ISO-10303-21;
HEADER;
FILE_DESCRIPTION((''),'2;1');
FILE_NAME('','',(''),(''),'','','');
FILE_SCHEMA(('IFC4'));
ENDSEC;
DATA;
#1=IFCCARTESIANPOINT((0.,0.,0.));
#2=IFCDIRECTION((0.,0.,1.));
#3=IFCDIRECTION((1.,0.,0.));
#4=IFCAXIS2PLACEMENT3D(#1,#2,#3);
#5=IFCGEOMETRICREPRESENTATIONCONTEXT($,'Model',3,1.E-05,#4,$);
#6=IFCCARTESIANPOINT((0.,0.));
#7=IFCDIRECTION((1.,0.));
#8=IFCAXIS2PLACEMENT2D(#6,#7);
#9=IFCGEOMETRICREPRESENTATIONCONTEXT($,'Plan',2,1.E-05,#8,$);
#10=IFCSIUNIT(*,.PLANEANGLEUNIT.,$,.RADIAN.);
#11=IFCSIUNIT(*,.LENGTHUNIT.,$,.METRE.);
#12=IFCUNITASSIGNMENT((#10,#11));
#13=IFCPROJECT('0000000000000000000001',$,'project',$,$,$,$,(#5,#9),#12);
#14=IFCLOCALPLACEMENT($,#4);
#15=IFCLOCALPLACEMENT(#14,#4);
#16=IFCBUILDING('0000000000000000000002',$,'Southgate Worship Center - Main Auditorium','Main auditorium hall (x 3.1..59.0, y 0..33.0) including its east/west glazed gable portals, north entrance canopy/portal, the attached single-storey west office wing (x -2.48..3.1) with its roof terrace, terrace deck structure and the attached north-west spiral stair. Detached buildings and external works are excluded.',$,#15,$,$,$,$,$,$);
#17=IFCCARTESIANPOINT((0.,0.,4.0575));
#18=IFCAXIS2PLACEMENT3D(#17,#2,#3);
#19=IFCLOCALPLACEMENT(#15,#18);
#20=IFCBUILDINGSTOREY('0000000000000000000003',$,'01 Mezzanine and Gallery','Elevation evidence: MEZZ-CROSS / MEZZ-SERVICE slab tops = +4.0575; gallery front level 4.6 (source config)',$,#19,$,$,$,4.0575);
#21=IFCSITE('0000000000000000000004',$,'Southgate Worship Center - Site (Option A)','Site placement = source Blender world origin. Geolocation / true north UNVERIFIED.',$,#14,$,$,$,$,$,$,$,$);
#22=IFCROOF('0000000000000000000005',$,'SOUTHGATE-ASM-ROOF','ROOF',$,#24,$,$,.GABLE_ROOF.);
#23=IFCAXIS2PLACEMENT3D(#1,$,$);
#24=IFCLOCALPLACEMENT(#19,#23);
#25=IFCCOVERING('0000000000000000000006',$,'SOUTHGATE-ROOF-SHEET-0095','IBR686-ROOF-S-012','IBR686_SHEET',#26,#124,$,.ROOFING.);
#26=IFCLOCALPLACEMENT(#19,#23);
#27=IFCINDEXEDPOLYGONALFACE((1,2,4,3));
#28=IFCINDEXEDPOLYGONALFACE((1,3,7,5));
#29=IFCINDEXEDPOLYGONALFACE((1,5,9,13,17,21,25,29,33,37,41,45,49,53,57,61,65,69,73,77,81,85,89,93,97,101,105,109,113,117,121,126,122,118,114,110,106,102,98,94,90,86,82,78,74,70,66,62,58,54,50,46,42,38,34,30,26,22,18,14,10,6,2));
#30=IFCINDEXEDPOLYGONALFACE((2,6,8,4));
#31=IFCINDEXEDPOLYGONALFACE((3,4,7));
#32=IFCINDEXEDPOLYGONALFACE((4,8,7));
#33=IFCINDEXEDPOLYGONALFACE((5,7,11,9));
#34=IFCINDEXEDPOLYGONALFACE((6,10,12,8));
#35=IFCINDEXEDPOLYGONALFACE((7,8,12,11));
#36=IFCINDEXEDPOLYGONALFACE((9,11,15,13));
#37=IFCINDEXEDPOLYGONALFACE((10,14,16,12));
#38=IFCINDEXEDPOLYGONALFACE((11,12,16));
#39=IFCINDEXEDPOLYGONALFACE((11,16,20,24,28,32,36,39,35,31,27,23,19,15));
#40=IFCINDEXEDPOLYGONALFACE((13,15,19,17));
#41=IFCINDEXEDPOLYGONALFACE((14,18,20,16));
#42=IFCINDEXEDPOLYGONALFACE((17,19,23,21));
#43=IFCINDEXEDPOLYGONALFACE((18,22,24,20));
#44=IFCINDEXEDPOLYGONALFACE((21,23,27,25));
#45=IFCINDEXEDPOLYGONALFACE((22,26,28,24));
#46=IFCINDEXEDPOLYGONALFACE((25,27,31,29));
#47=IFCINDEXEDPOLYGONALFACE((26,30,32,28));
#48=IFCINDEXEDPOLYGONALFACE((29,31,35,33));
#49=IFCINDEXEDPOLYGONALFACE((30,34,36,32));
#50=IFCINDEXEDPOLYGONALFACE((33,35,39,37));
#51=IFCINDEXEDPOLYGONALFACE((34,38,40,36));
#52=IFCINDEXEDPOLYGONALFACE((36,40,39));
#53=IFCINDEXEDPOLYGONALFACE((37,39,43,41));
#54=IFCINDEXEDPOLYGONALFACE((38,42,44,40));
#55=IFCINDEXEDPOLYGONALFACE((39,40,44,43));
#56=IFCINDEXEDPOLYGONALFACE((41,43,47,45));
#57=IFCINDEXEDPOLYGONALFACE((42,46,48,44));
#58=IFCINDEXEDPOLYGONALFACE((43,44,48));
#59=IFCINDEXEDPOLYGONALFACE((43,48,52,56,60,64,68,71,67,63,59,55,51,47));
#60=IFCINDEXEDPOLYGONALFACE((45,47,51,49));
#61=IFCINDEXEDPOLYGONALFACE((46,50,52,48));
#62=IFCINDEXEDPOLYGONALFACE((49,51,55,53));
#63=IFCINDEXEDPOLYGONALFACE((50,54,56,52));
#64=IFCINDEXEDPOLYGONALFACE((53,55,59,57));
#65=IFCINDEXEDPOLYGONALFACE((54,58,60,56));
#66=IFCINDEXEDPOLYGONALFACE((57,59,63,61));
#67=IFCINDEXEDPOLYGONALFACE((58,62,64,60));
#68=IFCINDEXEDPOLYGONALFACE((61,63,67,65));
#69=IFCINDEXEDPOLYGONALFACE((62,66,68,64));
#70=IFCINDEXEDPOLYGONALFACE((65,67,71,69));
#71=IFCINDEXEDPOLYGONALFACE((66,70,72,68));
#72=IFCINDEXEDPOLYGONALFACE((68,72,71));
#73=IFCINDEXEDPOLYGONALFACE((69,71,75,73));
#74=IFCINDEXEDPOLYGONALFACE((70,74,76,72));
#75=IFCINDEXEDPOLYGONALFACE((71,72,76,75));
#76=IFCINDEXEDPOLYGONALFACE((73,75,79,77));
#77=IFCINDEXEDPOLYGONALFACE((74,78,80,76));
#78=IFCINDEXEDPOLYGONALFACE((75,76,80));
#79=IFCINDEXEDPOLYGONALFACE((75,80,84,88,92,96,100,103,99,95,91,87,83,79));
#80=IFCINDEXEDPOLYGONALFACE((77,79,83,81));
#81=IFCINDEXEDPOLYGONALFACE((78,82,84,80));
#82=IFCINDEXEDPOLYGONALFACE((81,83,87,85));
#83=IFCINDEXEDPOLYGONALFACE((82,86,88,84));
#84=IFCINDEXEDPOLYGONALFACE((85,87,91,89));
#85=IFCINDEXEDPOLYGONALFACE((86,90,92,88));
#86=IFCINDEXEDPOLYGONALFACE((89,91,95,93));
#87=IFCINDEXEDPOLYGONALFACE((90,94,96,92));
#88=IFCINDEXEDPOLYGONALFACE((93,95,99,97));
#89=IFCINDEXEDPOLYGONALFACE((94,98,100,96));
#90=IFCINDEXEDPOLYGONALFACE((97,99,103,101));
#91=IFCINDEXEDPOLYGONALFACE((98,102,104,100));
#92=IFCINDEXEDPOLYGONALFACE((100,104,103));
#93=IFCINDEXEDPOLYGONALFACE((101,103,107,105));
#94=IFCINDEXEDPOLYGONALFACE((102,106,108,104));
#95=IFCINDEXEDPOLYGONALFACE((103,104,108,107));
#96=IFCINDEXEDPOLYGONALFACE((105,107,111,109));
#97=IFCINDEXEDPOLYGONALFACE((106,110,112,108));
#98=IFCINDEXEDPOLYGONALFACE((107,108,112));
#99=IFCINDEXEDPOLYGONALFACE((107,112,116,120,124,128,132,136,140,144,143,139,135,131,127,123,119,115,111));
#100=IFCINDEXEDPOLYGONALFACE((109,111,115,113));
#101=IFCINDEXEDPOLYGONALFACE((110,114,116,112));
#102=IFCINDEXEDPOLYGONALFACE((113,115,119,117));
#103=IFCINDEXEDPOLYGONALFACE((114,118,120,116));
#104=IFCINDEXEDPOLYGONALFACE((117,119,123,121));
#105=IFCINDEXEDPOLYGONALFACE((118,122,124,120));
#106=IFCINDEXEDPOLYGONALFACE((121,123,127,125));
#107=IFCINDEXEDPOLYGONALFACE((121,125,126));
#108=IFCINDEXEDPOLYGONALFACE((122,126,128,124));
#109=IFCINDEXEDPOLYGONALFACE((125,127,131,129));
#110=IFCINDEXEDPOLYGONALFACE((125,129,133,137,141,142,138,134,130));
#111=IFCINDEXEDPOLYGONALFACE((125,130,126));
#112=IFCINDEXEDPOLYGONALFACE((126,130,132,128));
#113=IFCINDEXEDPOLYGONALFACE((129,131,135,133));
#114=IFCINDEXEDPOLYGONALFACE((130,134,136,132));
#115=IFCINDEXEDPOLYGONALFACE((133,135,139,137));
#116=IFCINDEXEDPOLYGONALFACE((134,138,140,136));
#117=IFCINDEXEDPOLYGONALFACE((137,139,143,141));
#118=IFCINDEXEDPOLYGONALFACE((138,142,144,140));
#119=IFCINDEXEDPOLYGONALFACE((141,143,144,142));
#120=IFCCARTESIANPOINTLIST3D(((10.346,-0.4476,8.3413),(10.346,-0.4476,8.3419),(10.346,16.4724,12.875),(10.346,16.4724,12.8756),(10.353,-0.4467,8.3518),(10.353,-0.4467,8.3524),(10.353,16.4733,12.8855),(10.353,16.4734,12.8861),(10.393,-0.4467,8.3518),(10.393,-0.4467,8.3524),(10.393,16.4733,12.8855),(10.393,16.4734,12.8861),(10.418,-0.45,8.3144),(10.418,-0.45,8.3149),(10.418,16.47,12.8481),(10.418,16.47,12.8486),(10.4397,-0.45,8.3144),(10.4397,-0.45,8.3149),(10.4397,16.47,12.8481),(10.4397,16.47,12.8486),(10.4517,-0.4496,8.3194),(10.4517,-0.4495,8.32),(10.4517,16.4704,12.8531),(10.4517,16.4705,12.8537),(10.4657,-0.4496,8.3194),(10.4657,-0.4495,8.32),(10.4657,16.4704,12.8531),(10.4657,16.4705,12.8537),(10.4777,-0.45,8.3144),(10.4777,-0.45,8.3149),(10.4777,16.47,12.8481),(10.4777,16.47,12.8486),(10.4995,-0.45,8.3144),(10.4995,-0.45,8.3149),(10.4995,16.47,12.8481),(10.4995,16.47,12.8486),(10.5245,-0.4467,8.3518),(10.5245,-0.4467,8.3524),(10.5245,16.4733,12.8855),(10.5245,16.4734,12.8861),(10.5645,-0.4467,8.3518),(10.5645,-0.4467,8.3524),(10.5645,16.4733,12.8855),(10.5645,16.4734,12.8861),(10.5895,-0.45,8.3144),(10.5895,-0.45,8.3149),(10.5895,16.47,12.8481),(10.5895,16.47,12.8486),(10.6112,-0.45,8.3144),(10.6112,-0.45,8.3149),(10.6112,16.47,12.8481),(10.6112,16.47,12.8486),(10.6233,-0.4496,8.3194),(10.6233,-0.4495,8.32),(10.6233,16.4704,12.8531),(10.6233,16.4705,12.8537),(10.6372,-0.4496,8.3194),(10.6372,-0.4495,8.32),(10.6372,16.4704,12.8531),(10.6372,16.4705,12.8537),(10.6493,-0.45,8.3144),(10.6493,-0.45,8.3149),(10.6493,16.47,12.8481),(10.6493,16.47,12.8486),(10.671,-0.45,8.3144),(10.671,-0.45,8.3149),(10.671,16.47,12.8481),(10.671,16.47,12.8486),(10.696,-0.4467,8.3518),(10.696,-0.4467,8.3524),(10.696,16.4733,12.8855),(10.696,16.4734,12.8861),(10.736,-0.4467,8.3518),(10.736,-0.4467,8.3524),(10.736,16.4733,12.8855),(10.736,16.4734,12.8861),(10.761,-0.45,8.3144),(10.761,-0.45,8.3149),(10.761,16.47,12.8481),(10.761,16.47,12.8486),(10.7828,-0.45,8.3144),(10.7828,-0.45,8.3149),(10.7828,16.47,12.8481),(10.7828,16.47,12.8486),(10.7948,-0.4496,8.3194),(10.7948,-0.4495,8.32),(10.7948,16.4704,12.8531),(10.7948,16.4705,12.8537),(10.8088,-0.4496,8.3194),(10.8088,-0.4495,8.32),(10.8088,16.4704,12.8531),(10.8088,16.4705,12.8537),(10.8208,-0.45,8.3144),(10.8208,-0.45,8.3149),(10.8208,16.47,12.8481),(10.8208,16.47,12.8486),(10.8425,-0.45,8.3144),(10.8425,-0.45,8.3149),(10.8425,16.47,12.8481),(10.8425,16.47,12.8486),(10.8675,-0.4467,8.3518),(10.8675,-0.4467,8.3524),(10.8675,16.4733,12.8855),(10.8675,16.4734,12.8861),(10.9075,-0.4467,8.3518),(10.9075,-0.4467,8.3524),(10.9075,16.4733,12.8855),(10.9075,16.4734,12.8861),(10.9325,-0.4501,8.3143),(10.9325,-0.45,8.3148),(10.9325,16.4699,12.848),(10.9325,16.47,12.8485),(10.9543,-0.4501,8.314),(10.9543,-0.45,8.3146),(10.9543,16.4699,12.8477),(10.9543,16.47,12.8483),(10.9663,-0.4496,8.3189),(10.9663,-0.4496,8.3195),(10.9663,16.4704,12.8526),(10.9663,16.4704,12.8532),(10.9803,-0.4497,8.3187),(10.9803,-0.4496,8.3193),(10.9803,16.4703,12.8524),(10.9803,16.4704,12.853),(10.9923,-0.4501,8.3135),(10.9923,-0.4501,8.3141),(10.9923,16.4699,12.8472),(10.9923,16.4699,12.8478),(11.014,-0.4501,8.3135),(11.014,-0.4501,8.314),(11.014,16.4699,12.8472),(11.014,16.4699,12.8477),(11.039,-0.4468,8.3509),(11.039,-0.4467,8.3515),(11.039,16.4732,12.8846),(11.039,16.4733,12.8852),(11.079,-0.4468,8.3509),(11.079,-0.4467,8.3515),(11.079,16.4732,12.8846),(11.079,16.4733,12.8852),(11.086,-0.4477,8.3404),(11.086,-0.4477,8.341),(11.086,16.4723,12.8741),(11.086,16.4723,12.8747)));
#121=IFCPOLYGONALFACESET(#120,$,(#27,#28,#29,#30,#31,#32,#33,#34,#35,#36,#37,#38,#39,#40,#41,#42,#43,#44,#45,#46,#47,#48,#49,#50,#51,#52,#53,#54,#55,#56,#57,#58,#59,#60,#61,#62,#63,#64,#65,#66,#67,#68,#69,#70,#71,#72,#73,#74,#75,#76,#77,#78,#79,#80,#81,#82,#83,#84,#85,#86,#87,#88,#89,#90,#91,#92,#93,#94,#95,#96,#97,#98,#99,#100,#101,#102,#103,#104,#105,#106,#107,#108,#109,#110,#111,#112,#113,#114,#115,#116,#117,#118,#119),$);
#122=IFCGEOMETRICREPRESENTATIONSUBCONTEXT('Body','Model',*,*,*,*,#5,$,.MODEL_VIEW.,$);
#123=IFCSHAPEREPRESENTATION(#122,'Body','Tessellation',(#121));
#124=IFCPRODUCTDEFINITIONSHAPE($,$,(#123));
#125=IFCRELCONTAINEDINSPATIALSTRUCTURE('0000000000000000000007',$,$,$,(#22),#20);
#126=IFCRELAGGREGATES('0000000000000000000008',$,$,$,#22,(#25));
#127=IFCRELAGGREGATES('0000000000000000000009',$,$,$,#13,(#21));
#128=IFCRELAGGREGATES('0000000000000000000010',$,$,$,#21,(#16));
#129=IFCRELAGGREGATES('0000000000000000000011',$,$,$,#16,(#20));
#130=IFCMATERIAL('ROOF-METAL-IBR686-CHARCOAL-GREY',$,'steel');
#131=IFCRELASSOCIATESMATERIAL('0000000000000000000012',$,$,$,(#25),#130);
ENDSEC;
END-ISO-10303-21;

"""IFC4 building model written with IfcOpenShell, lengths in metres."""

from ifc_helpers import new_model, si_unit, frame, origin_with_axes, origin_2d_with_axis, place, context, subcontext, project, spatial, indexed_curve, outline, extrude, clip, halfspace, material, element, aggregate, save


model = new_model("IFC4")

# Units and contexts
model_context = context("Model", 3, precision=1e-05, world=origin_with_axes())
plan_context = context("Plan", 2, precision=1e-05, world=origin_2d_with_axis())
body_context = subcontext(model_context, "Body", "Model", "MODEL_VIEW")
ifc_project = project(units=[si_unit("PLANEANGLEUNIT", "RADIAN"), si_unit("LENGTHUNIT", "METRE")], contexts=[model_context, plan_context])

# Site, building, storey
site_placement = place(None, origin_with_axes())
site = spatial("IfcSite", under=ifc_project, at=site_placement, Name="Southgate Worship Center - Site (Option A)", Description="Site placement = source Blender world origin. Geolocation / true north UNVERIFIED.")
building_placement = place(site_placement, origin_with_axes())
building = spatial("IfcBuilding", under=site, at=building_placement, Name="Southgate Worship Center - Main Auditorium", Description="Main auditorium hall (x 3.1..59.0, y 0..33.0) including its east/west glazed gable portals, north entrance canopy/portal, the attached single-storey west office wing (x -2.48..3.1) with its roof terrace, terrace deck structure and the attached north-west spiral stair. Detached buildings and external works are excluded.")
storey_placement = place(building_placement, frame((0.0, 0.0, 4.0575), z_axis=(0.0, 0.0, 1.0), x_axis=(1.0, 0.0, 0.0)))
storey = spatial("IfcBuildingStorey", under=building, at=storey_placement, Name="01 Mezzanine and Gallery", Description="Elevation evidence: MEZZ-CROSS / MEZZ-SERVICE slab tops = +4.0575; gallery front level 4.6 (source config)", Elevation=4.0575)

# Roof, covering
roof_placement = place(storey_placement, origin_with_axes())
roof = element("IfcRoof", 1, at=roof_placement, inside=storey, Name="SOUTHGATE-ASM-ROOF", Description="ROOF", PredefinedType="GABLE_ROOF")
ifc_material_1 = material(Name="ROOF-METAL-IBR686-CHARCOAL-GREY", Category="steel")
covering_1_placement = place(roof_placement, frame((10.346, -0.4501, 8.3135), z_axis=(0.0, 0.0, 1.0), x_axis=(1.0, 0.0, 0.0)))
covering_1 = element("IfcCovering", 2, at=covering_1_placement, material=ifc_material_1, Name="SOUTHGATE-ROOF-SHEET-0095", Description="IBR686-ROOF-S-012", ObjectType="IBR686_SHEET", PredefinedType="ROOFING", context=body_context, shape_type="Clipping", body=[
    clip(clip(extrude(outline(indexed_curve([(0.0, 0.0), (0.025, 0.0353), (0.065, 0.0353), (0.072, 0.0254), (0.072, 0.0259), (0.065, 0.0358), (0.025, 0.0358), (0.0, 0.0005), (-0.0217, 0.0005), (-0.0337, 0.0053), (-0.0477, 0.0053), (-0.0597, 0.0005), (-0.0815, 0.0005), (-0.1065, 0.0358), (-0.1465, 0.0358), (-0.1715, 0.0005), (-0.1932, 0.0005), (-0.2052, 0.0053), (-0.2192, 0.0053), (-0.2312, 0.0005), (-0.253, 0.0005), (-0.278, 0.0358), (-0.318, 0.0358), (-0.343, 0.0005), (-0.3647, 0.0005), (-0.3767, 0.0053), (-0.3907, 0.0053), (-0.4028, 0.0005), (-0.4245, 0.0005), (-0.4495, 0.0358), (-0.4895, 0.0358), (-0.5145, 0.0004), (-0.5363, 0.0002), (-0.5483, 0.0048), (-0.5623, 0.0046), (-0.5743, -0.0003), (-0.596, -0.0004), (-0.621, 0.0349), (-0.661, 0.0349), (-0.668, 0.0251), (-0.668, 0.0246), (-0.661, 0.0344), (-0.621, 0.0344), (-0.596, -0.0009), (-0.5743, -0.0008), (-0.5623, 0.0041), (-0.5483, 0.0043), (-0.5363, -0.0003), (-0.5145, -0.0001), (-0.4895, 0.0353), (-0.4495, 0.0353), (-0.4245, 0.0), (-0.4028, 0.0), (-0.3907, 0.0048), (-0.3767, 0.0048), (-0.3647, 0.0), (-0.343, 0.0), (-0.318, 0.0353), (-0.278, 0.0353), (-0.253, 0.0), (-0.2312, 0.0), (-0.2192, 0.0048), (-0.2052, 0.0048), (-0.1932, 0.0), (-0.1715, 0.0), (-0.1465, 0.0353), (-0.1065, 0.0353), (-0.0815, 0.0), (-0.0597, 0.0), (-0.0477, 0.0048), (-0.0337, 0.0048), (-0.0217, 0.0), (0.0, 0.0)], self_intersect=False)), frame((0.072, -0.0003, 0.0008), z_axis=(0.0, 0.965926, 0.258819), x_axis=(-1.0, 0.0, 0.0)), (0.0, 0.0, 1.0), 17.5303), halfspace(frame((0.37, 0.0012, 0.014), z_axis=(0.0, -0.996022, 0.089113), x_axis=(1.0, 0.0, 0.0)), False)), halfspace(frame((0.37, 16.9212, 4.5477), z_axis=(0.0, 0.996021, -0.089119), x_axis=(-1.0, 0.0, 0.0)), False)),
])
aggregate(roof, [covering_1])

save(model, "model.ifc")
